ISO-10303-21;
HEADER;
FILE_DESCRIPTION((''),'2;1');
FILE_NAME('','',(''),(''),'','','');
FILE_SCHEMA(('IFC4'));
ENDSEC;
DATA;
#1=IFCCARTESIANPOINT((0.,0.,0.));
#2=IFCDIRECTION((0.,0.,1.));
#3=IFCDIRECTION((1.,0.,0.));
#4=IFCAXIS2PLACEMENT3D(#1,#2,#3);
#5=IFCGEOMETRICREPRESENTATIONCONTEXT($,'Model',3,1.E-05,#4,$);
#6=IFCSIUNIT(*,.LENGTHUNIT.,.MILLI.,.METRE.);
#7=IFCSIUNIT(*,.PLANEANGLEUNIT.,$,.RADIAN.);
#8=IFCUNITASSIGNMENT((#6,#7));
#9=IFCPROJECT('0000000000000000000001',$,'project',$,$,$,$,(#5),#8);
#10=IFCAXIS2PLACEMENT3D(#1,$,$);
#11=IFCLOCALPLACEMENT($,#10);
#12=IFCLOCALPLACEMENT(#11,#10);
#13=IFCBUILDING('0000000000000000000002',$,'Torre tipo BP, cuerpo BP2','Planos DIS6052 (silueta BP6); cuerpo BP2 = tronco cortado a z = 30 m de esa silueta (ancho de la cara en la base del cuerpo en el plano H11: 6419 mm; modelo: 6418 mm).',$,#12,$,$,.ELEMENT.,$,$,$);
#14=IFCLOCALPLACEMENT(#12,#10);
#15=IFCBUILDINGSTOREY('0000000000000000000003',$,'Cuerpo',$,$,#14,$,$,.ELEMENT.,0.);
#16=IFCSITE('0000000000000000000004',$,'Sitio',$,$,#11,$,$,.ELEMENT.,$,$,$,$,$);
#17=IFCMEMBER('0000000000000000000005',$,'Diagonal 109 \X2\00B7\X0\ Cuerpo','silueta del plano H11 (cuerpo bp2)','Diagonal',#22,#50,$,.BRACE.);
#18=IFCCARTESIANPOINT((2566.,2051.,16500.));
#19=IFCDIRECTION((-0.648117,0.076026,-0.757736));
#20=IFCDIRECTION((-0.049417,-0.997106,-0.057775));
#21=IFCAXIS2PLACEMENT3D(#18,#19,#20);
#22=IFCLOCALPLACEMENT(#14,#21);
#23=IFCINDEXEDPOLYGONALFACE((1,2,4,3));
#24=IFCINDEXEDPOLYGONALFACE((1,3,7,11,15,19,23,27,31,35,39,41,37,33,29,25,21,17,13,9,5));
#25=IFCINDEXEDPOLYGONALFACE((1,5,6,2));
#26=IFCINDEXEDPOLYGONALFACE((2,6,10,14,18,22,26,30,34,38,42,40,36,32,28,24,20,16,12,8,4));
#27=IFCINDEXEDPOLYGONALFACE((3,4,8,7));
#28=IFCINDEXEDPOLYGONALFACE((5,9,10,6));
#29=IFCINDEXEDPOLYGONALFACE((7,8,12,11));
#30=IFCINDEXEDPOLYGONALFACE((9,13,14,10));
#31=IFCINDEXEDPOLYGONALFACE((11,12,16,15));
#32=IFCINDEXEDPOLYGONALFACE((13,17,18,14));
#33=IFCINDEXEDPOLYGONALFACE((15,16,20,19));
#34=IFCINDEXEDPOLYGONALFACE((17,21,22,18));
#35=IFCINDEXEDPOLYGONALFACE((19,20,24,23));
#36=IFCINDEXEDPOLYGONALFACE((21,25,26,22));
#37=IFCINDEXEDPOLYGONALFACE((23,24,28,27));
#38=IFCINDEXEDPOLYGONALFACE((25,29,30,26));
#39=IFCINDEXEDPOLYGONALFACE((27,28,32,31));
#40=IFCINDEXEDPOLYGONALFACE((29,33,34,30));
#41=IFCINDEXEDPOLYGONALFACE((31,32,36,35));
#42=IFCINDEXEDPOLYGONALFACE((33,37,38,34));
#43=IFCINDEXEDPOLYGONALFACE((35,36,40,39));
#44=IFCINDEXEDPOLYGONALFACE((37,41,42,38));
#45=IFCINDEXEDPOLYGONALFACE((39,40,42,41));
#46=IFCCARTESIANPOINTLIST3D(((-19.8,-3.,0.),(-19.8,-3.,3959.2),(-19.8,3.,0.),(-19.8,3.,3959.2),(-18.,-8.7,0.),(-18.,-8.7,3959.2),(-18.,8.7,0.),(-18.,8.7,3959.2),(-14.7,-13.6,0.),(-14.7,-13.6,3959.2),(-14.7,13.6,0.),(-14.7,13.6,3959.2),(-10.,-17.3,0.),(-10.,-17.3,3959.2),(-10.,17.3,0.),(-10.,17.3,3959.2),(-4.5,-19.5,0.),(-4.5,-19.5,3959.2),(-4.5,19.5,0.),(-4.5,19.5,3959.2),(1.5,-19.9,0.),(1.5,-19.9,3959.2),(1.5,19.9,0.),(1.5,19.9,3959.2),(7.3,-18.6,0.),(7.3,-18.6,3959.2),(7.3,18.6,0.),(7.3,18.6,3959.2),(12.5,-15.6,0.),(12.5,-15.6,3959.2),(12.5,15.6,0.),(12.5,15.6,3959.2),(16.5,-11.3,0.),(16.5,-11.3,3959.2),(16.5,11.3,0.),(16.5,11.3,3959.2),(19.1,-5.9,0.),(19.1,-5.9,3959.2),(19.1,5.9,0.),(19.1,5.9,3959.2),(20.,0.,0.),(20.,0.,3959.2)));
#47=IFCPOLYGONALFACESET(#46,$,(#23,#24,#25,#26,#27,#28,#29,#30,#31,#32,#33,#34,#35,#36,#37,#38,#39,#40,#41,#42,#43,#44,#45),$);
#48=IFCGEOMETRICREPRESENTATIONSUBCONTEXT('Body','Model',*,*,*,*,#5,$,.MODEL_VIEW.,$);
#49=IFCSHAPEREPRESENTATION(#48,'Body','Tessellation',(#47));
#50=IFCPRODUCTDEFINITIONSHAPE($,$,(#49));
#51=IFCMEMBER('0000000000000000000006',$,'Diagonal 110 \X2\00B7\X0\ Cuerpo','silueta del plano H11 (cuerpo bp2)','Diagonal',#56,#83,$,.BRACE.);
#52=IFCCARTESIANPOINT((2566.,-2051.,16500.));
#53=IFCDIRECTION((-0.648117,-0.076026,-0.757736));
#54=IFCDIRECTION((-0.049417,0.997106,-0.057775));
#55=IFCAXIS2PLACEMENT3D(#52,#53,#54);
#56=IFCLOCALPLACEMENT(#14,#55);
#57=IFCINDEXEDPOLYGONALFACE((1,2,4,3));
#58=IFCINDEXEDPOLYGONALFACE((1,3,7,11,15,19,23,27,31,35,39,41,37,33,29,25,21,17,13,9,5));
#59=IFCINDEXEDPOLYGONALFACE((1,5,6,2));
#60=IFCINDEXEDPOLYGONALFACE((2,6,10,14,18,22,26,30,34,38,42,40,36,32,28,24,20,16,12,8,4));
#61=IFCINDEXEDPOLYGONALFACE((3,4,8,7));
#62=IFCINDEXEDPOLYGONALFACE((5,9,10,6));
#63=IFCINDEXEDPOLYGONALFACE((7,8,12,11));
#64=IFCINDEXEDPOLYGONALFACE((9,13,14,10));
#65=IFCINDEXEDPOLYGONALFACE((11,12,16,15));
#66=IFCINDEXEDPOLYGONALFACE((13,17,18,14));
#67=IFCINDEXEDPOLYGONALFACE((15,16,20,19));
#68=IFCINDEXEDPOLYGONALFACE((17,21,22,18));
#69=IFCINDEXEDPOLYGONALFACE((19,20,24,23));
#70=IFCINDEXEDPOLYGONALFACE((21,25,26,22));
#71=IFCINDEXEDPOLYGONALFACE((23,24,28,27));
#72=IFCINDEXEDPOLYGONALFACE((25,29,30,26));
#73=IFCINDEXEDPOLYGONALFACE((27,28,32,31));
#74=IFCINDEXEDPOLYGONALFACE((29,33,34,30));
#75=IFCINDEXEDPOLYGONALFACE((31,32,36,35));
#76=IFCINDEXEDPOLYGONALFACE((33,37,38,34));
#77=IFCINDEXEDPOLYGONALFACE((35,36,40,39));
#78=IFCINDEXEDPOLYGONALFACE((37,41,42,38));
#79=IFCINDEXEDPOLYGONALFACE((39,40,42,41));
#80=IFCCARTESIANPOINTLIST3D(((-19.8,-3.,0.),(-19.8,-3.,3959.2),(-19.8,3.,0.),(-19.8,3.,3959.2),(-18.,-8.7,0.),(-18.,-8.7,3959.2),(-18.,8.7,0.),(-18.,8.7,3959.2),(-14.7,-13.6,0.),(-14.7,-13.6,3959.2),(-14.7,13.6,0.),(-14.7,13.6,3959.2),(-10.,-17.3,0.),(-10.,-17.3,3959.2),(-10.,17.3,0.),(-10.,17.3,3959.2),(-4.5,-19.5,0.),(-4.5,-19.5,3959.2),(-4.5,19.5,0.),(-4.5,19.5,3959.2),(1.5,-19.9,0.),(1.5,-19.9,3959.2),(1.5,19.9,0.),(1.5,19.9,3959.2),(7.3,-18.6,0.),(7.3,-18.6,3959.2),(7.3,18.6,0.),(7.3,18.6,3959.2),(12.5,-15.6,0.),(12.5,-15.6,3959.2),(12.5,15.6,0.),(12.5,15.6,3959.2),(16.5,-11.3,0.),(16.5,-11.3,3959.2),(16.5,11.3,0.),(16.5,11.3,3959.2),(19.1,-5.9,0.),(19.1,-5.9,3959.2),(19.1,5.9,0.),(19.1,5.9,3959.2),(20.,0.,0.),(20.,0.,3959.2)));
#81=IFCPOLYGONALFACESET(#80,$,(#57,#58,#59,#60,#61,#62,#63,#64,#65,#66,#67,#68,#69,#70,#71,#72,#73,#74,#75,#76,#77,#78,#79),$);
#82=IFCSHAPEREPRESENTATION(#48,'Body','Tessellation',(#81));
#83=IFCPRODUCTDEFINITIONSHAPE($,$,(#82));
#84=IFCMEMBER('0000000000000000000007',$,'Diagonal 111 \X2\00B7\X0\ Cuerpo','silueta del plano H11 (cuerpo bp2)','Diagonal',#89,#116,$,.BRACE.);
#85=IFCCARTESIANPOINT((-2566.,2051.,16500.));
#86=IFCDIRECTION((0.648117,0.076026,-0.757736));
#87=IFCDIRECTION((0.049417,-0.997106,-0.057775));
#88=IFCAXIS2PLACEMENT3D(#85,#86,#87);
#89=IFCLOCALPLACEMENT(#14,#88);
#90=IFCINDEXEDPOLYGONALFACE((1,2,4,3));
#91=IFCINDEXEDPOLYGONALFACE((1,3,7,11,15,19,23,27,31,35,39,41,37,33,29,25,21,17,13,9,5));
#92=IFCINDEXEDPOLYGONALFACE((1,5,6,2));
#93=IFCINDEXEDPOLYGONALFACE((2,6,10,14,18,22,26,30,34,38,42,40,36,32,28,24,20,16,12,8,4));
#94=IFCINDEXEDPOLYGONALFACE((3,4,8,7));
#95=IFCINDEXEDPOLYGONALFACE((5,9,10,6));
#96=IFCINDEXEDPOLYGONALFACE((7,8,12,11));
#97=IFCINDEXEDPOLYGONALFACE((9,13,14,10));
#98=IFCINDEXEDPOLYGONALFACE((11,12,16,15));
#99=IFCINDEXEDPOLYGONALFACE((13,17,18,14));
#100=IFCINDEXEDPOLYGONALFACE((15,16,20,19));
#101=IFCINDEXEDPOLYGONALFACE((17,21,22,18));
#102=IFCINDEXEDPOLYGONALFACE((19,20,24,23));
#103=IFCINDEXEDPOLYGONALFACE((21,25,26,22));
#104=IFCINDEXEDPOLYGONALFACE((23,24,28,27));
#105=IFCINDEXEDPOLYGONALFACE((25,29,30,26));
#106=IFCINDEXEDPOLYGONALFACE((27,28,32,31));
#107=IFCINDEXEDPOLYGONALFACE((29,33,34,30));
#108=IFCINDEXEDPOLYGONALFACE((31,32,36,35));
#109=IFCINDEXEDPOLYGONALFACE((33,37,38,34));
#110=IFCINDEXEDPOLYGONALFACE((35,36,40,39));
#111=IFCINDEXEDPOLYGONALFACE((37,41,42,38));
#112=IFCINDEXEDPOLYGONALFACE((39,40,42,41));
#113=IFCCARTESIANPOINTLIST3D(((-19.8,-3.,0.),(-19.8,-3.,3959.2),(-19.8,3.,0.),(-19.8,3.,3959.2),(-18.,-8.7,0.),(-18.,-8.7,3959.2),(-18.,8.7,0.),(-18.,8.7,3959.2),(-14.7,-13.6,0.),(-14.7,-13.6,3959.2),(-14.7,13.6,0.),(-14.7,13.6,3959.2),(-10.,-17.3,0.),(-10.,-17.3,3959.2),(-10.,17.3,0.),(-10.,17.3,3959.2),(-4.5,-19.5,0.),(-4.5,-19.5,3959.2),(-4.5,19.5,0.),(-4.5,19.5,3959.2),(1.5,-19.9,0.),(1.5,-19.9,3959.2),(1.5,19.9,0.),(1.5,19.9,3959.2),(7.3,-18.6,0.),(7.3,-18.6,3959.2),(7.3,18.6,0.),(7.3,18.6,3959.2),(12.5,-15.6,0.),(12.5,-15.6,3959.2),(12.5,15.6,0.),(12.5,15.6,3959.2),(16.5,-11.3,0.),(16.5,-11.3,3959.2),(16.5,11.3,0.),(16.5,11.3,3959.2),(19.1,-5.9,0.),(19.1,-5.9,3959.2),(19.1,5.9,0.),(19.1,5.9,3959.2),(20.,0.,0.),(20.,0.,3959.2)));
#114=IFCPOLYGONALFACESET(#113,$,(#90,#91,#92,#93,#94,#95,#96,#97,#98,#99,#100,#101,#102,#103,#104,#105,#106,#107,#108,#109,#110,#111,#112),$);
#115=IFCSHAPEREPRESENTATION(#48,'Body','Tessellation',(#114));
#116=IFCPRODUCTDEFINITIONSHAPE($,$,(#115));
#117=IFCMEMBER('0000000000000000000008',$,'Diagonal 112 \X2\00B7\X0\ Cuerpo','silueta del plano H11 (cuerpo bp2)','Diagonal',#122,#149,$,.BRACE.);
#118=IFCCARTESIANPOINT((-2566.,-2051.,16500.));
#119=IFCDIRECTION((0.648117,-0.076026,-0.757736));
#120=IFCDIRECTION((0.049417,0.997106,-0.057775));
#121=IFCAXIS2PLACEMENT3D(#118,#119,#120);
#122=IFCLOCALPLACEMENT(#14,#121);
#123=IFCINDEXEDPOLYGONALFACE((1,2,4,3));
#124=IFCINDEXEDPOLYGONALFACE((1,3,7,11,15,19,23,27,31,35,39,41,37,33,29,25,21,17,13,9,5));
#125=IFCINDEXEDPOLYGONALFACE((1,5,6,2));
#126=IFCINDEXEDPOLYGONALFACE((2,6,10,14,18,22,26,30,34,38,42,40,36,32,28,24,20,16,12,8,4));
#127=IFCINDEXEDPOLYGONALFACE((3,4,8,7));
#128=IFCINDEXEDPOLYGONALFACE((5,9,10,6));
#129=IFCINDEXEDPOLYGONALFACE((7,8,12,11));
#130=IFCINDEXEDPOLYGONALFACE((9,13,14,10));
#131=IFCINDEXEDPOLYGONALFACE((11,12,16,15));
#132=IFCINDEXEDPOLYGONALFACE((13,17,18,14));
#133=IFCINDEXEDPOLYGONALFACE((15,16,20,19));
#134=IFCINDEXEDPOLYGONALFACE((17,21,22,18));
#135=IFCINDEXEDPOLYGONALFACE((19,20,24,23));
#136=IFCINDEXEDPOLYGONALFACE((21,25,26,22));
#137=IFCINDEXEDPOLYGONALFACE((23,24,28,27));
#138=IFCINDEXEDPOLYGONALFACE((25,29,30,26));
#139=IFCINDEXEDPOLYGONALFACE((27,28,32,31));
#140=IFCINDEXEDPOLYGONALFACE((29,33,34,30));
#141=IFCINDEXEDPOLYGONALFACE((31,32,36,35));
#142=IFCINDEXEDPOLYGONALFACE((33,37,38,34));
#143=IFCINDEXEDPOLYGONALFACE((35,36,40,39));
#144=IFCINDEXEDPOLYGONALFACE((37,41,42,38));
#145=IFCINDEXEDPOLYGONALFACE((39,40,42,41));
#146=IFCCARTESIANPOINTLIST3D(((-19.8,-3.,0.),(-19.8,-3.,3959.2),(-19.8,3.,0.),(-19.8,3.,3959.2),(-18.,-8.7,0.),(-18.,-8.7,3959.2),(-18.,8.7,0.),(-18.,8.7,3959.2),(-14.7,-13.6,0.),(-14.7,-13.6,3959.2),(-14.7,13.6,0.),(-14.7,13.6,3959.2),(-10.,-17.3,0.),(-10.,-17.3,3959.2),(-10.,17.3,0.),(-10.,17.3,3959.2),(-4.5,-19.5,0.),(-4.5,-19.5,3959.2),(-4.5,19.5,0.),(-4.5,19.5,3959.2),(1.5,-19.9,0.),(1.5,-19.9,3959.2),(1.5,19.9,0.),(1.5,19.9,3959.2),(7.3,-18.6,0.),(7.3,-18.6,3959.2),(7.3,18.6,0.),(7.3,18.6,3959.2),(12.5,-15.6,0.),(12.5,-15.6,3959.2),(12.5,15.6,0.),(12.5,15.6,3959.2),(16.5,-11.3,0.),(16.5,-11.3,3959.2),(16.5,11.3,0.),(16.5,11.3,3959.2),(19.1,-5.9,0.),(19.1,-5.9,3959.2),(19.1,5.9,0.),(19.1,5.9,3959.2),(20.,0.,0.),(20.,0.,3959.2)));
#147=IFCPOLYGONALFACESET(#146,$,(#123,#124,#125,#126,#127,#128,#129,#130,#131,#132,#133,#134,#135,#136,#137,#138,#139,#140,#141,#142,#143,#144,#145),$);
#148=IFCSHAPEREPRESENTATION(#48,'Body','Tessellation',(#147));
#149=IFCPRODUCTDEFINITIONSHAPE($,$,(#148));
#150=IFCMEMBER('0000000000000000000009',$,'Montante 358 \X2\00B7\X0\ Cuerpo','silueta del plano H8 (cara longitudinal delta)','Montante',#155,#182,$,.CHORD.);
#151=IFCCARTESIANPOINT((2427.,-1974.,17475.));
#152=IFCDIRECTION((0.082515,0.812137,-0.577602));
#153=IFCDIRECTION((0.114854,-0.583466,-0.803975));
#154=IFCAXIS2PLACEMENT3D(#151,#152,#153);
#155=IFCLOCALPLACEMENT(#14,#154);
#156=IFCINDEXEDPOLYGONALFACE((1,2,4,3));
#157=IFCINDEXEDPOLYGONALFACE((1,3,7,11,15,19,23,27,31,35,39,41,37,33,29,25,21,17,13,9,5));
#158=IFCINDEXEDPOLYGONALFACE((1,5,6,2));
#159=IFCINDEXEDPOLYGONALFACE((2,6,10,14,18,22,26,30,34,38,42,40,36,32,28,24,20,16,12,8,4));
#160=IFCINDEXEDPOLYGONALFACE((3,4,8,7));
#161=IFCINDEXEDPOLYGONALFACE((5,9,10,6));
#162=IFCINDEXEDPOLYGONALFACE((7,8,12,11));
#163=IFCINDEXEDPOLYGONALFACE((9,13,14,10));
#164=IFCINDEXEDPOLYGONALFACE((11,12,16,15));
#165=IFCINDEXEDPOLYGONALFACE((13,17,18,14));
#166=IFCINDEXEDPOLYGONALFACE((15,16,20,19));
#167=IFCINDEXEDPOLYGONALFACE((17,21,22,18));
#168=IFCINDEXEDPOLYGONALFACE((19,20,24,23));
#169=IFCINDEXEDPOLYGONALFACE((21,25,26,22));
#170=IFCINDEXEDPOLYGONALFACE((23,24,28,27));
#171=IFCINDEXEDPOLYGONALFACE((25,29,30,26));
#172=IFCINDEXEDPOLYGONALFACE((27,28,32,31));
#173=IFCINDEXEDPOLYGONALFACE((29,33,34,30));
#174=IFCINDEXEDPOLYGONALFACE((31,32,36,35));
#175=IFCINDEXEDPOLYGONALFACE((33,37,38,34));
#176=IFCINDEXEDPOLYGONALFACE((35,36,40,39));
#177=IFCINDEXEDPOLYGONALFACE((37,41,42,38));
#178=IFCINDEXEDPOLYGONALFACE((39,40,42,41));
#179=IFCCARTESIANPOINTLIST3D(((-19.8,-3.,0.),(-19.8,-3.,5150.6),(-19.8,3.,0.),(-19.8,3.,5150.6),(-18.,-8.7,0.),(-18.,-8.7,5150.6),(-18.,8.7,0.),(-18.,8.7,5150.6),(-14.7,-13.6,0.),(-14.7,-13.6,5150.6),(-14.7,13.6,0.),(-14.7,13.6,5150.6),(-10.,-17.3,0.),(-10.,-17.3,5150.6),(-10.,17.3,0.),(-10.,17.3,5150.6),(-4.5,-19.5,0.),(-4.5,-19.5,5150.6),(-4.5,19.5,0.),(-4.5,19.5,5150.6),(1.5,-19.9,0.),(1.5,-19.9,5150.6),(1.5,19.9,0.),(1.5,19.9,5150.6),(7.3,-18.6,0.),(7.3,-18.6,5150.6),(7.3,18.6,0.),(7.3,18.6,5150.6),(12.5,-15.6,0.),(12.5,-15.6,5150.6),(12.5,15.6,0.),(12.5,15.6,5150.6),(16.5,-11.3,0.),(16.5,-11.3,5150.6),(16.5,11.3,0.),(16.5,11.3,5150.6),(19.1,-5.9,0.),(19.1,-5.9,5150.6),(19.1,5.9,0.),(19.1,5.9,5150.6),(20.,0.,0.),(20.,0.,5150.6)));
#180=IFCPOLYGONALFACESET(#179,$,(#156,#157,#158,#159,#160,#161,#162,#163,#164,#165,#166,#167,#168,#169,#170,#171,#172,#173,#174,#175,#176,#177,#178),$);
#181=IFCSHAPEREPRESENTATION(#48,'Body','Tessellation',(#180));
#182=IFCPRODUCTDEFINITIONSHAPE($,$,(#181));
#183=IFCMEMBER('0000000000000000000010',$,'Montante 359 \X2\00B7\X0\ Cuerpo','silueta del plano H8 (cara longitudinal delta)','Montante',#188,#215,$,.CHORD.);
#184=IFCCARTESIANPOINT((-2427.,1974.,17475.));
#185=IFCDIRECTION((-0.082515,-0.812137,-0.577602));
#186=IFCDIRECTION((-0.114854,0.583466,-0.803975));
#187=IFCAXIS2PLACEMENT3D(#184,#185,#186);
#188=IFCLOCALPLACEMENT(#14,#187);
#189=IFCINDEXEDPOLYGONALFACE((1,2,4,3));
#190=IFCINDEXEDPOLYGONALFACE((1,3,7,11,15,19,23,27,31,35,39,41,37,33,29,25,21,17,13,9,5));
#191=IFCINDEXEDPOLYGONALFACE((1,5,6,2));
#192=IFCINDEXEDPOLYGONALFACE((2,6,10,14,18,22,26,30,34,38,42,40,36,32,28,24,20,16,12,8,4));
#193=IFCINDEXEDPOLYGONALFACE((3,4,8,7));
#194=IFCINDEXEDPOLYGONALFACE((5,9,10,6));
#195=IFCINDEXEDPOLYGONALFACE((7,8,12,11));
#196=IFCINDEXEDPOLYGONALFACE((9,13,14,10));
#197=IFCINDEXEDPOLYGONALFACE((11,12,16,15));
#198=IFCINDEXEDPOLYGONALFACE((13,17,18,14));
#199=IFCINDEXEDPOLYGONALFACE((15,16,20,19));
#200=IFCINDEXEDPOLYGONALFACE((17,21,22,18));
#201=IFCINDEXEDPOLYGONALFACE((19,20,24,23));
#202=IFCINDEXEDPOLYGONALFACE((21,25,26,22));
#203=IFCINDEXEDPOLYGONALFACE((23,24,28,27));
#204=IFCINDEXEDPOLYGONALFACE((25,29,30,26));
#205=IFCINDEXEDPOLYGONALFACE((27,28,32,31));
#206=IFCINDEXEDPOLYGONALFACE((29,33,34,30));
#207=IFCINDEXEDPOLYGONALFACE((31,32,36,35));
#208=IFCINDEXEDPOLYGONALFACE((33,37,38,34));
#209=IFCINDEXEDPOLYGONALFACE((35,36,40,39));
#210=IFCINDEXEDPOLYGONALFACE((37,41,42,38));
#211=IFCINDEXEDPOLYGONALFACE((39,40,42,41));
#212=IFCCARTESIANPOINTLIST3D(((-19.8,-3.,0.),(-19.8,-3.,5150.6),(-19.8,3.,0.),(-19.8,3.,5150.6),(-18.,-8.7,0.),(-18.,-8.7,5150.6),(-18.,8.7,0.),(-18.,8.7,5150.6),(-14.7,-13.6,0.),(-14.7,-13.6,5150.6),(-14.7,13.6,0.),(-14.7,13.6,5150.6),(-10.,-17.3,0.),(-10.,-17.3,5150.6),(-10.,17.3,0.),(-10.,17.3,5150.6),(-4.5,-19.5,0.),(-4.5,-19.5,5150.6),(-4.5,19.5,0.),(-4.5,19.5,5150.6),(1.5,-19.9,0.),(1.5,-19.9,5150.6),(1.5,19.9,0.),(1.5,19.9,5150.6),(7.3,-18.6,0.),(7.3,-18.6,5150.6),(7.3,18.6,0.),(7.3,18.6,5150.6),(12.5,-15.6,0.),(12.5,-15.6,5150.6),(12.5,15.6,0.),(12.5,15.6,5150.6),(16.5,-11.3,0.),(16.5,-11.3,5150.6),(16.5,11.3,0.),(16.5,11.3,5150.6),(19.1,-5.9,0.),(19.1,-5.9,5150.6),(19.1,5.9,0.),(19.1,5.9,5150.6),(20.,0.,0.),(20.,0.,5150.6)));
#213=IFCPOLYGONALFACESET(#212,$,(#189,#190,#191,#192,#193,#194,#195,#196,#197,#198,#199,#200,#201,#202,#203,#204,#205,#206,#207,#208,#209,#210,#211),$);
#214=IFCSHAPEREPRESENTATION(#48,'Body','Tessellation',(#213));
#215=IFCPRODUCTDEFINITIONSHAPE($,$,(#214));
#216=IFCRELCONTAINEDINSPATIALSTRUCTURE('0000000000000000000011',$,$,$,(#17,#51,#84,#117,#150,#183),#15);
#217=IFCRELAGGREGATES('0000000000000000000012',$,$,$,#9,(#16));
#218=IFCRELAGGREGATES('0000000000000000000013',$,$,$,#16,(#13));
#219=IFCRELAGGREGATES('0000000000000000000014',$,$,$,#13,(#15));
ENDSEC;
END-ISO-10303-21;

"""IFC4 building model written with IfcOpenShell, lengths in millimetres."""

from ifc_helpers import new_model, si_unit, frame, origin, origin_with_axes, place, context, subcontext, project, spatial, circle, extrude, element, save


model = new_model("IFC4")

# Units and contexts
model_context = context("Model", 3, precision=1e-05, world=origin_with_axes())
body_context = subcontext(model_context, "Body", "Model", "MODEL_VIEW")
ifc_project = project(units=[si_unit("LENGTHUNIT", "METRE", prefix="MILLI"), si_unit("PLANEANGLEUNIT", "RADIAN")], contexts=[model_context])

# Site, building, storey
site_placement = place(None, origin())
site = spatial("IfcSite", under=ifc_project, at=site_placement, Name="Sitio", CompositionType="ELEMENT")
building_placement = place(site_placement, origin())
building = spatial("IfcBuilding", under=site, at=building_placement, Name="Torre tipo BP, cuerpo BP2", Description="Planos DIS6052 (silueta BP6); cuerpo BP2 = tronco cortado a z = 30 m de esa silueta (ancho de la cara en la base del cuerpo en el plano H11: 6419 mm; modelo: 6418 mm).", CompositionType="ELEMENT")
storey_placement = place(building_placement, origin())
storey = spatial("IfcBuildingStorey", under=building, at=storey_placement, Name="Cuerpo", CompositionType="ELEMENT", Elevation=0.0)

# Members
for number, where, z_axis, x_axis, name in (
    (1, (2566.0, 2051.0, 16500.0), (-0.648117, 0.076026, -0.757736), (-0.049417, -0.997106, -0.057775), "Diagonal 109 · Cuerpo"),
    (2, (2566.0, -2051.0, 16500.0), (-0.648117, -0.076026, -0.757736), (-0.049417, 0.997106, -0.057775), "Diagonal 110 · Cuerpo"),
    (3, (-2566.0, 2051.0, 16500.0), (0.648117, 0.076026, -0.757736), (0.049417, -0.997106, -0.057775), "Diagonal 111 · Cuerpo"),
    (4, (-2566.0, -2051.0, 16500.0), (0.648117, -0.076026, -0.757736), (0.049417, 0.997106, -0.057775), "Diagonal 112 · Cuerpo"),
):
    element("IfcMember", number, at=place(storey_placement, frame(where, z_axis=z_axis, x_axis=x_axis)), inside=storey, Name=name, Description="silueta del plano H11 (cuerpo bp2)", ObjectType="Diagonal", PredefinedType="BRACE", context=body_context, shape_type="SweptSolid", body=[
        extrude(circle(Radius=20.0), None, (0.0, 0.0, 1.0), 3959.2),
    ])
for number, where, z_axis, x_axis, name in (
    (5, (2427.0, -1974.0, 17475.0), (0.082515, 0.812137, -0.577602), (0.114854, -0.583466, -0.803975), "Montante 358 · Cuerpo"),
    (6, (-2427.0, 1974.0, 17475.0), (-0.082515, -0.812137, -0.577602), (-0.114854, 0.583466, -0.803975), "Montante 359 · Cuerpo"),
):
    element("IfcMember", number, at=place(storey_placement, frame(where, z_axis=z_axis, x_axis=x_axis)), inside=storey, Name=name, Description="silueta del plano H8 (cara longitudinal delta)", ObjectType="Montante", PredefinedType="CHORD", context=body_context, shape_type="SweptSolid", body=[
        extrude(circle(Radius=20.0), None, (0.0, 0.0, 1.0), 5150.6),
    ])

save(model, "model.ifc")
